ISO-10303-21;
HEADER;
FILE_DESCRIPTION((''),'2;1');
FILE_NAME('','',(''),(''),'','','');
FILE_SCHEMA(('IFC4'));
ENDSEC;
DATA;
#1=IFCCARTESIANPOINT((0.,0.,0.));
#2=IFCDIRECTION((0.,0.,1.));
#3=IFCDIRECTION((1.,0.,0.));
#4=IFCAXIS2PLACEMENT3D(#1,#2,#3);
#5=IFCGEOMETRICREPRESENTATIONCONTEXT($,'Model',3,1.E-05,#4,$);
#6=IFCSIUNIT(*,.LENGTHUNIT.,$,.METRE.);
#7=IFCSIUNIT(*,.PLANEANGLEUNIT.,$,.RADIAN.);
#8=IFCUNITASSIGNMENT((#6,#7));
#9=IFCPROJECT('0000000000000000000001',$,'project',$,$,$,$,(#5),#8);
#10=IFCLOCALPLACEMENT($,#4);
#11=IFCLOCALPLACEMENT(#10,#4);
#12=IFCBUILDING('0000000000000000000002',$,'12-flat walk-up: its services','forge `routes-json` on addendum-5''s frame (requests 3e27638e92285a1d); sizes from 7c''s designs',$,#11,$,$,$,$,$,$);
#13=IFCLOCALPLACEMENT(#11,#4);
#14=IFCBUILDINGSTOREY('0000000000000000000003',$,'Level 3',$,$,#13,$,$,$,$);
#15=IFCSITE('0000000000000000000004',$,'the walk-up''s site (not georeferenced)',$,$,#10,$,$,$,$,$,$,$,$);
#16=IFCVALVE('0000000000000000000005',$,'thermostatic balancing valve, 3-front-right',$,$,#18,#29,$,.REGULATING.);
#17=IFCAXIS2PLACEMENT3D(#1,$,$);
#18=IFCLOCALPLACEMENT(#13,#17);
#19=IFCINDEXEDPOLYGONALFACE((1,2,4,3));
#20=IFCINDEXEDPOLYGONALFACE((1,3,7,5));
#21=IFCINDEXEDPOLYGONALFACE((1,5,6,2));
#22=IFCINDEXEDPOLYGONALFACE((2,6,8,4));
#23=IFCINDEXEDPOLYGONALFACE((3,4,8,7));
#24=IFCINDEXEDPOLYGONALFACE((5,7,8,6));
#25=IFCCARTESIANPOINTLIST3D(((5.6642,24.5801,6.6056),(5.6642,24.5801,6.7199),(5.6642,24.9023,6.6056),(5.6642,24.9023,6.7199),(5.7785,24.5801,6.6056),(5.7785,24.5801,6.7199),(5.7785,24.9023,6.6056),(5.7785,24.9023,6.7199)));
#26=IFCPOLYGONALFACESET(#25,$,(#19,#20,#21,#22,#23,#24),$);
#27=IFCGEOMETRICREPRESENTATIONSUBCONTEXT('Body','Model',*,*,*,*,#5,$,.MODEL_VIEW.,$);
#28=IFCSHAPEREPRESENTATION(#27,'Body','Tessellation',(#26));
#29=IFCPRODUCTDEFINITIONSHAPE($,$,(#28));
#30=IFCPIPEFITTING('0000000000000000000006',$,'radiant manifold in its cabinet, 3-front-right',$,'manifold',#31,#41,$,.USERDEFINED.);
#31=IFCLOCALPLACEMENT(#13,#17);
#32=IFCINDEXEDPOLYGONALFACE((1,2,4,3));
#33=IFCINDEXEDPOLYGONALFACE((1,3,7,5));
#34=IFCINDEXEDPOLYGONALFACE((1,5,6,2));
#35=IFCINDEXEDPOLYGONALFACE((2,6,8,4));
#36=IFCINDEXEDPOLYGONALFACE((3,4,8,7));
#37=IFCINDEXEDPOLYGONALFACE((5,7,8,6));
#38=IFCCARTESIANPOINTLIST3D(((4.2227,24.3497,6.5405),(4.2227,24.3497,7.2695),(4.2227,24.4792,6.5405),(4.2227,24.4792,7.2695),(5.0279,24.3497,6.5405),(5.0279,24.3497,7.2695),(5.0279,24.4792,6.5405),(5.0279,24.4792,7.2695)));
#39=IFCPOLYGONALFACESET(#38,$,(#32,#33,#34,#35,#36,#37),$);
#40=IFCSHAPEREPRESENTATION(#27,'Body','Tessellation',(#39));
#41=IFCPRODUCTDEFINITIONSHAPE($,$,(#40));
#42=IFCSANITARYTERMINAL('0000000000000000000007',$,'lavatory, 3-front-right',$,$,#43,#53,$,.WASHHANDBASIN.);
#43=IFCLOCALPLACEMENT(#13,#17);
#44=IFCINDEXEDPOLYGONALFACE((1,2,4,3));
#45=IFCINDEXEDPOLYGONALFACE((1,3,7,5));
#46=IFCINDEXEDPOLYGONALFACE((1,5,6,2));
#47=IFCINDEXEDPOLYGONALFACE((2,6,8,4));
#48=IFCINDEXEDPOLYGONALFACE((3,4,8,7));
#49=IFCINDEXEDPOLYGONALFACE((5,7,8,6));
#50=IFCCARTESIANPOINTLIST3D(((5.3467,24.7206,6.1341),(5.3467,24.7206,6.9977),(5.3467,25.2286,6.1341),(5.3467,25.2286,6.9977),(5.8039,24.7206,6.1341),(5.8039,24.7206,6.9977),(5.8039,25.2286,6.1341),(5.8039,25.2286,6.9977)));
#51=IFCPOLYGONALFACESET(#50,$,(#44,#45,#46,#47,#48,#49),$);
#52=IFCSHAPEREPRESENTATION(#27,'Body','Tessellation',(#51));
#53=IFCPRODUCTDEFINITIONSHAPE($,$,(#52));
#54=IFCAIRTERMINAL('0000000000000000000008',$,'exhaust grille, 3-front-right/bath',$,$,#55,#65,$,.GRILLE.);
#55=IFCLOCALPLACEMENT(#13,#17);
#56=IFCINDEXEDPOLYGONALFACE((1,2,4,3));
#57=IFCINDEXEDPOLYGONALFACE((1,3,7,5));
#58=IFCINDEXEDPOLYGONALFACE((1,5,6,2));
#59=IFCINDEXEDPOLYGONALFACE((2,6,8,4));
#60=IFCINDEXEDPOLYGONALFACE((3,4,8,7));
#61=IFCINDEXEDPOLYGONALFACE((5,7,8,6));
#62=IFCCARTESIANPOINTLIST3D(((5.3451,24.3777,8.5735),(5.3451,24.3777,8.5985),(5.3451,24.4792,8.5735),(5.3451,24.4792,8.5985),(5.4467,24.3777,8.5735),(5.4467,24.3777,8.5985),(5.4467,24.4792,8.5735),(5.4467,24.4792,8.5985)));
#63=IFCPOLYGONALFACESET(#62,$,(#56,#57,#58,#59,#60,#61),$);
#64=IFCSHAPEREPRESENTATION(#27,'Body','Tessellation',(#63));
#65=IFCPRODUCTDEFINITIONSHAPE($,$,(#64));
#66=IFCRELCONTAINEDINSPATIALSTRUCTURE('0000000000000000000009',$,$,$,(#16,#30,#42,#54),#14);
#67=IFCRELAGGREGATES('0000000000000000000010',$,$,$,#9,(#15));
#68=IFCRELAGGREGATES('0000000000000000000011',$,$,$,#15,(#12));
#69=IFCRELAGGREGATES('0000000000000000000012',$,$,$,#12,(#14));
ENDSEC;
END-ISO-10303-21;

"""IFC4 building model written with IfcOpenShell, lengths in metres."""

from ifc_helpers import new_model, si_unit, frame, frame_2d, origin, origin_with_axes, place, context, subcontext, project, spatial, rectangle, extrude, element, save


model = new_model("IFC4")

# Units and contexts
model_context = context("Model", 3, precision=1e-05, world=origin_with_axes())
body_context = subcontext(model_context, "Body", "Model", "MODEL_VIEW")
ifc_project = project(units=[si_unit("LENGTHUNIT", "METRE"), si_unit("PLANEANGLEUNIT", "RADIAN")], contexts=[model_context])

# Site, building, storey
site_placement = place(None, origin_with_axes())
site = spatial("IfcSite", under=ifc_project, at=site_placement, Name="the walk-up's site (not georeferenced)")
building_placement = place(site_placement, origin_with_axes())
building = spatial("IfcBuilding", under=site, at=building_placement, Name="12-flat walk-up: its services", Description="forge `routes-json` on addendum-5's frame (requests 3e27638e92285a1d); sizes from 7c's designs")
storey_placement = place(building_placement, origin_with_axes())
storey = spatial("IfcBuildingStorey", under=building, at=storey_placement, Name="Level 3")

# Valve
valve_placement = place(storey_placement, frame((5.6642, 24.5801, 6.6056), z_axis=(0.0, 0.0, 1.0), x_axis=(1.0, 0.0, 0.0)))
element("IfcValve", 1, at=valve_placement, inside=storey, Name="thermostatic balancing valve, 3-front-right", PredefinedType="REGULATING", context=body_context, shape_type="SweptSolid", body=[
    extrude(rectangle(XDim=0.1143, YDim=0.3223, at=frame_2d((0.0572, 0.1611))), origin(), (0.0, 0.0, 1.0), 0.1143),
])

# Pipe fitting
pipe_fitting_1_placement = place(storey_placement, frame((4.2227, 24.3497, 6.5405), z_axis=(0.0, 0.0, 1.0), x_axis=(1.0, 0.0, 0.0)))
element("IfcPipeFitting", 2, at=pipe_fitting_1_placement, inside=storey, Name="radiant manifold in its cabinet, 3-front-right", ObjectType="manifold", PredefinedType="USERDEFINED", context=body_context, shape_type="SweptSolid", body=[
    extrude(rectangle(XDim=0.8052, YDim=0.1295, at=frame_2d((0.4026, 0.0648))), origin(), (0.0, 0.0, 1.0), 0.729),
])

# Sanitary terminal
sanitary_terminal_placement = place(storey_placement, frame((5.3467, 24.7205, 6.1341), z_axis=(0.0, 0.0, 1.0), x_axis=(1.0, 0.0, 0.0)))
element("IfcSanitaryTerminal", 3, at=sanitary_terminal_placement, inside=storey, Name="lavatory, 3-front-right", PredefinedType="WASHHANDBASIN", context=body_context, shape_type="SweptSolid", body=[
    extrude(rectangle(XDim=0.4572, YDim=0.508, at=frame_2d((0.2286, 0.254))), origin(), (0.0, 0.0, 1.0), 0.8636),
])

# Air terminal
air_terminal_placement = place(storey_placement, frame((5.3451, 24.3777, 8.5735), z_axis=(0.0, 0.0, 1.0), x_axis=(1.0, 0.0, 0.0)))
element("IfcAirTerminal", 4, at=air_terminal_placement, inside=storey, Name="exhaust grille, 3-front-right/bath", PredefinedType="GRILLE", context=body_context, shape_type="SweptSolid", body=[
    extrude(rectangle(XDim=0.1016, YDim=0.1016, at=frame_2d((0.0508, 0.0508))), origin(), (0.0, 0.0, 1.0), 0.025),
])

save(model, "model.ifc")
